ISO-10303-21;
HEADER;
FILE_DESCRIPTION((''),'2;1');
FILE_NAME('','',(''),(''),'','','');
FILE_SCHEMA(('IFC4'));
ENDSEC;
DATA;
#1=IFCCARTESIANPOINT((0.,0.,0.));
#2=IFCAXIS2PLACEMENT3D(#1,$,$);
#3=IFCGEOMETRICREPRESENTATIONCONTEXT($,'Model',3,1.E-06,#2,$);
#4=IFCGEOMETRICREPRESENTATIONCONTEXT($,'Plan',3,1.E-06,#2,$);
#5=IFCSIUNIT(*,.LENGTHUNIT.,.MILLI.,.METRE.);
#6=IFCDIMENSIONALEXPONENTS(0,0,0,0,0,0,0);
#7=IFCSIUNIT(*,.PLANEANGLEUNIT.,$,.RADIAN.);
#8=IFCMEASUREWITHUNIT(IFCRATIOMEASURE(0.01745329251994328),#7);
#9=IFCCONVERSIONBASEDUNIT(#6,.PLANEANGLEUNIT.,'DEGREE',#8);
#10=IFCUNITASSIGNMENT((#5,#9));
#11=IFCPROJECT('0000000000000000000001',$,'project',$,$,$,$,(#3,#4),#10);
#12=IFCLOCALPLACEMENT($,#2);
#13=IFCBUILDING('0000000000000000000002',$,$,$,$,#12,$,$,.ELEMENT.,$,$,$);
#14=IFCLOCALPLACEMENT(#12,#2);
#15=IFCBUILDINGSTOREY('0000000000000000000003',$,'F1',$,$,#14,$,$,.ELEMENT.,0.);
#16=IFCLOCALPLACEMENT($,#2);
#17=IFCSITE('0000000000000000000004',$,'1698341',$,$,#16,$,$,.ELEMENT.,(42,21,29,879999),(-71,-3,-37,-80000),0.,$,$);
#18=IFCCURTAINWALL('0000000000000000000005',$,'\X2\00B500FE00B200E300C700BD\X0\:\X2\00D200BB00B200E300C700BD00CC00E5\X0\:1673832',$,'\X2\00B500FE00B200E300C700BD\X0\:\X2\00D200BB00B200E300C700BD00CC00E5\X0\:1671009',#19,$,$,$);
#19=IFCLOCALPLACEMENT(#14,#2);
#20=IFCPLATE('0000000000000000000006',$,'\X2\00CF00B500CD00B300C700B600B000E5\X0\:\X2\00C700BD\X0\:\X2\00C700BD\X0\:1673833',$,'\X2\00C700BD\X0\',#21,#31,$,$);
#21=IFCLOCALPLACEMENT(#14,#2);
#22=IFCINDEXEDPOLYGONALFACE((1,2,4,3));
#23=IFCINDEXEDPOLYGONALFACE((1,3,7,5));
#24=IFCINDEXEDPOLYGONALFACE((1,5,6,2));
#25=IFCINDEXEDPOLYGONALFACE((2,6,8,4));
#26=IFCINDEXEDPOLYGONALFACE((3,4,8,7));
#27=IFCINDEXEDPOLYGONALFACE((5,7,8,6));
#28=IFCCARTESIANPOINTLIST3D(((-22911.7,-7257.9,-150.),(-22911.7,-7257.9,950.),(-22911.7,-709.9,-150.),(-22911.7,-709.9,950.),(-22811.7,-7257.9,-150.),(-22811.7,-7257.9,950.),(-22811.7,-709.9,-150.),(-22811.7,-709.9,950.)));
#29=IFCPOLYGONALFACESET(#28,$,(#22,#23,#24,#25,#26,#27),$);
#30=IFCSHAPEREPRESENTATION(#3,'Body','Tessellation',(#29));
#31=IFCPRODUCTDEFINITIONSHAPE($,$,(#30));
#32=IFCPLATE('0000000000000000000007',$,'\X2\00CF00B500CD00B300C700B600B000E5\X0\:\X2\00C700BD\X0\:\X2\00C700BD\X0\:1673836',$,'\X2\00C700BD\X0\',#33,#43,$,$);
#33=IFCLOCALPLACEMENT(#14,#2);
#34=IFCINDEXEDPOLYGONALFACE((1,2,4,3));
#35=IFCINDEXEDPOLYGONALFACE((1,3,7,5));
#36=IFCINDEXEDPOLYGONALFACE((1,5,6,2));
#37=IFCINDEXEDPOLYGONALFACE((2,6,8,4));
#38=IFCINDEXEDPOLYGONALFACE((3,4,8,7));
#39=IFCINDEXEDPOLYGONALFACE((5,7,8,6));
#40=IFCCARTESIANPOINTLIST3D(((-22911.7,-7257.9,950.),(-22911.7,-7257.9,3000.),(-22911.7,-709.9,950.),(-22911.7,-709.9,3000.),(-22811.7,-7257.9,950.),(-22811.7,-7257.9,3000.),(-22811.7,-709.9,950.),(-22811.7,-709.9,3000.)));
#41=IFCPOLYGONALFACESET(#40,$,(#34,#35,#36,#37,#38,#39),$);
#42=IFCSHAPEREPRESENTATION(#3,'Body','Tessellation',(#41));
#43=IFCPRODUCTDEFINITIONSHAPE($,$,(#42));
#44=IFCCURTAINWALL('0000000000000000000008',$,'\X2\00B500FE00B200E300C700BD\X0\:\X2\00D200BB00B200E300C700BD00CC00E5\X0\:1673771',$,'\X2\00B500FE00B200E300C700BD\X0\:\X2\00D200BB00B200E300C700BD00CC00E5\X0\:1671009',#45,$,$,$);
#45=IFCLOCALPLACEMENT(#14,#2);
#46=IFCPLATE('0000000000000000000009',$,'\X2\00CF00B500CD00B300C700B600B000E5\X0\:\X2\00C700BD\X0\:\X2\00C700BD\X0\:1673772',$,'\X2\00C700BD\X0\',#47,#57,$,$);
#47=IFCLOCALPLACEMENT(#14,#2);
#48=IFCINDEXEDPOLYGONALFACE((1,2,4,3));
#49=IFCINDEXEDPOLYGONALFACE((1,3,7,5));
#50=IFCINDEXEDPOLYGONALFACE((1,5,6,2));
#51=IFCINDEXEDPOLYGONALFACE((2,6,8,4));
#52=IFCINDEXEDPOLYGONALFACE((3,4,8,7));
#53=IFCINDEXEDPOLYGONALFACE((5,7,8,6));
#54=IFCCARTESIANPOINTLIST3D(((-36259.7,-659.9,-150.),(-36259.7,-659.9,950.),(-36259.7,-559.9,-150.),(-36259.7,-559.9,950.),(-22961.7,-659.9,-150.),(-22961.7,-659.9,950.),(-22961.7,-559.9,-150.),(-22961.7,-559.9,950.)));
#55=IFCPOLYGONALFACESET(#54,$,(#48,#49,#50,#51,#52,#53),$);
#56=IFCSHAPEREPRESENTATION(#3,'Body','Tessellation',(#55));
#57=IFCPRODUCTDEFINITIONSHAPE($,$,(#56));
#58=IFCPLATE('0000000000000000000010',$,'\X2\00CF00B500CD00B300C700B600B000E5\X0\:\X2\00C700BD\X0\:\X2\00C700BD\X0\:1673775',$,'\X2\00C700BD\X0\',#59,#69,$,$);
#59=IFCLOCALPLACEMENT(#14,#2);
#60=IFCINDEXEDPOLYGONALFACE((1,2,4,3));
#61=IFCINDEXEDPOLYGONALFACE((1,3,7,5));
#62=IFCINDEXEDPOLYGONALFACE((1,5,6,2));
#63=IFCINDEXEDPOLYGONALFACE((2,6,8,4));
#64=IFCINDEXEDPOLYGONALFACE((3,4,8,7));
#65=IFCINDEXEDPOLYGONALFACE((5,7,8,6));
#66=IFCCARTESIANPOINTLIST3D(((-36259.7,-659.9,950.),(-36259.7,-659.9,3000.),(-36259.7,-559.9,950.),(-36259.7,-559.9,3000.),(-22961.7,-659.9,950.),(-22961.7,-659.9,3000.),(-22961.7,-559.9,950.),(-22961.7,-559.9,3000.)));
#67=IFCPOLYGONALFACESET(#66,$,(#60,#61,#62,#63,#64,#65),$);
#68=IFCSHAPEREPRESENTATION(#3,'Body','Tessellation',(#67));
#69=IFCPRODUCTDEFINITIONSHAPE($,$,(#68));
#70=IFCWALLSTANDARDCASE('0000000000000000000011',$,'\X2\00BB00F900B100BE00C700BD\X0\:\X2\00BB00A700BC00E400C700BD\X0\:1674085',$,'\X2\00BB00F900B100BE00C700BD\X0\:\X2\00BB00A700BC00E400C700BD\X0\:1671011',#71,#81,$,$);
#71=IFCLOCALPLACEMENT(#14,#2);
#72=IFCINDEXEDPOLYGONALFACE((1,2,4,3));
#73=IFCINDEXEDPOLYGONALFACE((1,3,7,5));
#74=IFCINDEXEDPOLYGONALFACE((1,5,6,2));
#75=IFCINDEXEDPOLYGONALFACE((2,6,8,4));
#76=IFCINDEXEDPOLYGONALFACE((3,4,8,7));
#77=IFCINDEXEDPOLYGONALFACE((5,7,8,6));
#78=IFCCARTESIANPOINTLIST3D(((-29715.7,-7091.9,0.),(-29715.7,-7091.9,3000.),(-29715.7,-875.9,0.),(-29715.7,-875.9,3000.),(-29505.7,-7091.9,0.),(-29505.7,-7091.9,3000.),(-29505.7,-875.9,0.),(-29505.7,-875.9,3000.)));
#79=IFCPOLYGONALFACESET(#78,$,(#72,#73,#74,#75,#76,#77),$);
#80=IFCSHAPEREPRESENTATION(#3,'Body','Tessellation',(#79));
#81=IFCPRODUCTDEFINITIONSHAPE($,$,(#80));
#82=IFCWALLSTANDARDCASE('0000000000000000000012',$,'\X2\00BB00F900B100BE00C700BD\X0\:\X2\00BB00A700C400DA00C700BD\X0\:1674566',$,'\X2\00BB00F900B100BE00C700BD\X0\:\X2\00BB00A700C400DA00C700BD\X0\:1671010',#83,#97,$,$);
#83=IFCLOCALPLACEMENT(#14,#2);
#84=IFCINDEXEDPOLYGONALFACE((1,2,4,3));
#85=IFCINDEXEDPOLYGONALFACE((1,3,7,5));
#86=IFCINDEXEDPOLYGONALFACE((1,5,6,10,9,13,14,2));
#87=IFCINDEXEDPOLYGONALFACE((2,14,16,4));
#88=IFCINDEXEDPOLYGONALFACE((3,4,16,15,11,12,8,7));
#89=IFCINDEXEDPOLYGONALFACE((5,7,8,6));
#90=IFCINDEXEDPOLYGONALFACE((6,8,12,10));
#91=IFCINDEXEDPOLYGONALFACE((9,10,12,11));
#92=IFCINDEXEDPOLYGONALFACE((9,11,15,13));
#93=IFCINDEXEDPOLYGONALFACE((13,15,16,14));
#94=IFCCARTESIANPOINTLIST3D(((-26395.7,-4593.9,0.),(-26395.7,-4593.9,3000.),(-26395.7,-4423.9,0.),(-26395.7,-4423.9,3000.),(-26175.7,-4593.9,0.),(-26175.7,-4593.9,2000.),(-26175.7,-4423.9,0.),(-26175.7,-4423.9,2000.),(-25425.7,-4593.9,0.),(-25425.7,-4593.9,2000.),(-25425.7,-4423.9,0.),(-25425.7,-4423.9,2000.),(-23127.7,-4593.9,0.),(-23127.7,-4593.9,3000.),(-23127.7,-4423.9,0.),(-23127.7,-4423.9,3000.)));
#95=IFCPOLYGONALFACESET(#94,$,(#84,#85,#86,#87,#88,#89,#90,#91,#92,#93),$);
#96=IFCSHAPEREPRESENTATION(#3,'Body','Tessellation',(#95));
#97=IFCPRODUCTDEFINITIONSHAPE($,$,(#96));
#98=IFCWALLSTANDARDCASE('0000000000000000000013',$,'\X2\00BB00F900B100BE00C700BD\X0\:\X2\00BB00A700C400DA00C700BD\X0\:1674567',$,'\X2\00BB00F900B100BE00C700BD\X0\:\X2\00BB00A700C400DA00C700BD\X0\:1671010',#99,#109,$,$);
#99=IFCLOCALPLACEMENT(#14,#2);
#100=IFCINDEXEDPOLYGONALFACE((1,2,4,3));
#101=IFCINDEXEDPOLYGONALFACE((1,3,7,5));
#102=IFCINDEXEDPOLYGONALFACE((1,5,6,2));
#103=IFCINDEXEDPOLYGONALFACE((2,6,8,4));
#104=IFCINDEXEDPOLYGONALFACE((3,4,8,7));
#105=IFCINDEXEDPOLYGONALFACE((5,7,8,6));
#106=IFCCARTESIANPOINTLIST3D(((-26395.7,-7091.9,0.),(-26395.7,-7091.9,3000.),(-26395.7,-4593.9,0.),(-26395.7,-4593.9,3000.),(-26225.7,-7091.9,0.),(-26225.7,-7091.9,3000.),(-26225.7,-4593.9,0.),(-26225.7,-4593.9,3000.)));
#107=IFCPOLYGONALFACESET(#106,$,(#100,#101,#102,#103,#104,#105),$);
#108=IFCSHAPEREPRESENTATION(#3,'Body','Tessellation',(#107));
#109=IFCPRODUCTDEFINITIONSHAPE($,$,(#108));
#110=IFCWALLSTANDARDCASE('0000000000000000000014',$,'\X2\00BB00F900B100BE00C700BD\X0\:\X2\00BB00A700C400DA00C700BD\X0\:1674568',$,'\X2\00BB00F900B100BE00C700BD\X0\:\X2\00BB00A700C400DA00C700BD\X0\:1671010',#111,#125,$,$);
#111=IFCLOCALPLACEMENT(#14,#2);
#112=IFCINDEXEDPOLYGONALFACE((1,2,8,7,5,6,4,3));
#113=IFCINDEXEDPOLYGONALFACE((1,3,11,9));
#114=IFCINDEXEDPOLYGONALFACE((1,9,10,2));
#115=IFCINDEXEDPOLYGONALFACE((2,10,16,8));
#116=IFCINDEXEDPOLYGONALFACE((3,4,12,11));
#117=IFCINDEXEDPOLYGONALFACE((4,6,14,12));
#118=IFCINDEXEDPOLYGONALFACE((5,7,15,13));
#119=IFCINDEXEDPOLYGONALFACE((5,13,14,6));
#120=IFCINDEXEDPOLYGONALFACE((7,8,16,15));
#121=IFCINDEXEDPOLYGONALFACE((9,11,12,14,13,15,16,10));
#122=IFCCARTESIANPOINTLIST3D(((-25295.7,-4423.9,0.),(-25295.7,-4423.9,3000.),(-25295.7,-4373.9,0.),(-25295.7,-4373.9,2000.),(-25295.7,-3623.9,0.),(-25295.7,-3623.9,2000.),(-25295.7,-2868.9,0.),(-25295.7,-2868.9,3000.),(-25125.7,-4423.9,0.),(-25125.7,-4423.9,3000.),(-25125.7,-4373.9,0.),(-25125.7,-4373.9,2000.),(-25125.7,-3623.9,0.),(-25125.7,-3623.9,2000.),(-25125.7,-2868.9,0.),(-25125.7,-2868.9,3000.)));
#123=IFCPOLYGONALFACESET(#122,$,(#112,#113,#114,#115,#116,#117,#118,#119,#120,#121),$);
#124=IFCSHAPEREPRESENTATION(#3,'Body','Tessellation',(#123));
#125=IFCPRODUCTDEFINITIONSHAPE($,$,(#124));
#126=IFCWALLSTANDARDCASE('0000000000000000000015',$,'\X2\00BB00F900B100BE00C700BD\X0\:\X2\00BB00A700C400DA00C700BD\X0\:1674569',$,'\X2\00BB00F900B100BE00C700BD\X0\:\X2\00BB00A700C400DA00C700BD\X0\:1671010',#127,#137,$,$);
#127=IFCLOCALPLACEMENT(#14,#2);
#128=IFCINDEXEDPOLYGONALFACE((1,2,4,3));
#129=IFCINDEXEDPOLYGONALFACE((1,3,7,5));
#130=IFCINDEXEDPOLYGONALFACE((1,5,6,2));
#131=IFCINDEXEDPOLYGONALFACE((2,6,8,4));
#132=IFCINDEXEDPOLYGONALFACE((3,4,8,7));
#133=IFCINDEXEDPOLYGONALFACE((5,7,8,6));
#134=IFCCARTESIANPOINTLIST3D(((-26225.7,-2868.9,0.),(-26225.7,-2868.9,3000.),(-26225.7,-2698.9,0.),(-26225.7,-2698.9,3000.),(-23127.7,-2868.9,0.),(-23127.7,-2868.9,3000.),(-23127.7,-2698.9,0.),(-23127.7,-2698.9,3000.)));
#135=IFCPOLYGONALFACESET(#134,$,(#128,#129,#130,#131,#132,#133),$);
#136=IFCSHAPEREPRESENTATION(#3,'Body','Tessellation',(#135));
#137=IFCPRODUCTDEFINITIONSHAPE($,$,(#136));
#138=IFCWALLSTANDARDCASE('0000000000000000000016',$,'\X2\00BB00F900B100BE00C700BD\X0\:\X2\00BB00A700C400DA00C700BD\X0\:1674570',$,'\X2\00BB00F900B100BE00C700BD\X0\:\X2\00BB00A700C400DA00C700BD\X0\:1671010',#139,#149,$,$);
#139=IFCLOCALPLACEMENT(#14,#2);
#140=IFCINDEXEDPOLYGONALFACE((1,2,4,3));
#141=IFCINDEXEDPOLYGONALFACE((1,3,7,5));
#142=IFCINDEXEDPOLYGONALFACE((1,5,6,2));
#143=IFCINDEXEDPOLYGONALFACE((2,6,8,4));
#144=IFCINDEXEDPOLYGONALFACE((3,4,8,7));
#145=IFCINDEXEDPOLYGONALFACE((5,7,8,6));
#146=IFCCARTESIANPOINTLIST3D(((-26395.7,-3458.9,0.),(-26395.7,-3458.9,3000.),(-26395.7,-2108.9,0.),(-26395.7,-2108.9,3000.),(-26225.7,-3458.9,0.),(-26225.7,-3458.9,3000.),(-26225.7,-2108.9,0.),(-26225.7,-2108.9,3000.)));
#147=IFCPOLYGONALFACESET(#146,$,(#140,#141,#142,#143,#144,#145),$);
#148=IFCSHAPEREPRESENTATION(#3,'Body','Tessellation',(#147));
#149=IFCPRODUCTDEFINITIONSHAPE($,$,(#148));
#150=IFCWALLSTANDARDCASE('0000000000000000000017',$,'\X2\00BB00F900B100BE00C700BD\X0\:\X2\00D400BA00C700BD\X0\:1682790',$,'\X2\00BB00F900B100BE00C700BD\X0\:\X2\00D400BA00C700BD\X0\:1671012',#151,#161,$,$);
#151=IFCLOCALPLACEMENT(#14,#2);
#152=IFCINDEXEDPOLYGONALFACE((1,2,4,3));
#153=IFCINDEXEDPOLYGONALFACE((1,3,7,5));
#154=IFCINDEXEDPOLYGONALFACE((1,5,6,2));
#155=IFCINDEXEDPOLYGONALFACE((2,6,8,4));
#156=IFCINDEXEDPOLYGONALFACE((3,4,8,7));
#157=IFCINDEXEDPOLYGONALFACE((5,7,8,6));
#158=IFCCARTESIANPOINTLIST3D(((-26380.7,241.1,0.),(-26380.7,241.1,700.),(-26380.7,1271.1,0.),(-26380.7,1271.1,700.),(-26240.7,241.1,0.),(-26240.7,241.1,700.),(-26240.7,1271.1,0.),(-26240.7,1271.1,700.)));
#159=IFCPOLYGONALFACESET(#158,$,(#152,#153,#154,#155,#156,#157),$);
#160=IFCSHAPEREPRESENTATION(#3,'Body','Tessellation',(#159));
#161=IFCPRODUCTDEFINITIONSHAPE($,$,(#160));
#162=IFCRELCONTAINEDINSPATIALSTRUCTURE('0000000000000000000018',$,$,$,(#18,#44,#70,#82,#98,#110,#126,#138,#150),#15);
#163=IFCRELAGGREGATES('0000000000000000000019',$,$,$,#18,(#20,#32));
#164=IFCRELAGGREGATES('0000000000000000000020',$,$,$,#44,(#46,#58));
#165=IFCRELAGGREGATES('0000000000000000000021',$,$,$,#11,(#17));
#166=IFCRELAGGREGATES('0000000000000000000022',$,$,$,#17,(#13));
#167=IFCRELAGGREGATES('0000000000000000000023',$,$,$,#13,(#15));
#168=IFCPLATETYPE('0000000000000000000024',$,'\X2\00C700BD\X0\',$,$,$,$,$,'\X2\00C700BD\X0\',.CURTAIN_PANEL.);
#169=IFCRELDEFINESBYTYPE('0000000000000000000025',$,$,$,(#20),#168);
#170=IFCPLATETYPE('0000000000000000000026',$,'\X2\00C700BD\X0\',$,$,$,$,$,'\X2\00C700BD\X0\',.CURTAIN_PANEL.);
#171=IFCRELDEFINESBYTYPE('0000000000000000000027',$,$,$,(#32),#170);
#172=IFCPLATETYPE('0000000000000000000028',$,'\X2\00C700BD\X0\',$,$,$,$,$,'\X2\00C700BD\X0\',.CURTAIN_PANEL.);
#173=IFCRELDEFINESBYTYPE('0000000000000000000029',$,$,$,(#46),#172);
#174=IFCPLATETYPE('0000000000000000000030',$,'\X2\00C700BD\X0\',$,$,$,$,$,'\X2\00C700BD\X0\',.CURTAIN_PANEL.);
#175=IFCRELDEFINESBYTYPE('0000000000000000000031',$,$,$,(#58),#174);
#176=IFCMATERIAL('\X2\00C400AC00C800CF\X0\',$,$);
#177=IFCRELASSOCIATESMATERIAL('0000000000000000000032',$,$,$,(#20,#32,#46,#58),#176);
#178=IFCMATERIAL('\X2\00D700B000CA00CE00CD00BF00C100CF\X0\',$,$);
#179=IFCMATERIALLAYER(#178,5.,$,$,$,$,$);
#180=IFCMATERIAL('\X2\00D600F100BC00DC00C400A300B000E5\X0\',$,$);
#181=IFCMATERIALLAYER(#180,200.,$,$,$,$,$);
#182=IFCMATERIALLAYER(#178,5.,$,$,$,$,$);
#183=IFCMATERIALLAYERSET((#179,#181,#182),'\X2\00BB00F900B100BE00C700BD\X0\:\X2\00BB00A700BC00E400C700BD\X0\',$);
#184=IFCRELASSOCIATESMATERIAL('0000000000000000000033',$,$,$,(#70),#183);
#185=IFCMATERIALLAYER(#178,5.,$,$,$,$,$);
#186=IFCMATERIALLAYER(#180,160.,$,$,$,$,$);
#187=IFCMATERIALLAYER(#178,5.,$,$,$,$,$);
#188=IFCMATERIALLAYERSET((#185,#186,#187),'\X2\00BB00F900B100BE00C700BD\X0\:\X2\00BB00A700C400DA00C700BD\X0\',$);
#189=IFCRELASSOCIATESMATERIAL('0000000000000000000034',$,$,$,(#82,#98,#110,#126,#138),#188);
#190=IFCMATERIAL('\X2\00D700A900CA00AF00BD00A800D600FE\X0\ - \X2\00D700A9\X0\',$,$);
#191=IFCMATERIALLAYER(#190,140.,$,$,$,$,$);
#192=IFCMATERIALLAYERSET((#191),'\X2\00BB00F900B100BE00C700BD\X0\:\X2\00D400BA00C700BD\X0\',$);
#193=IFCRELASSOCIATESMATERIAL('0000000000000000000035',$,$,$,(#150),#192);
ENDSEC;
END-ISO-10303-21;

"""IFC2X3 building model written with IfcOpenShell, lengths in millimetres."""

from ifc_helpers import new_model, entity, si_unit, converted_unit, frame, frame_2d, origin, origin_2d_with_axis, place, context, project, spatial, rectangle, extrude, source, transform, mapped, material, layer, layer_set, layer_usage, type_object, type_shapes, element, aggregate, save


model = new_model("IFC2X3")

# Units and contexts
model_context = context("Model", 3, precision=1e-06, world=origin())
plan_context = context("Plan", 3, precision=1e-06, world=origin())
ifc_project = project(units=[si_unit("LENGTHUNIT", "METRE", prefix="MILLI"), converted_unit("PLANEANGLEUNIT", "DEGREE", entity("IfcRatioMeasure", 0.01745329251994328), si_unit("PLANEANGLEUNIT", "RADIAN"), dimensions=[0, 0, 0, 0, 0, 0, 0])], contexts=[model_context, plan_context])

# Site, building, storey
site_placement = place(None, origin())
site = spatial("IfcSite", under=ifc_project, at=site_placement, Name="1698341", CompositionType="ELEMENT", RefLatitude=(42, 21, 29, 879999), RefLongitude=(-71, -3, -37, -80000), RefElevation=0.0)
building_placement = place(None, origin())
building = spatial("IfcBuilding", under=site, at=building_placement, CompositionType="ELEMENT")
storey_placement = place(building_placement, origin())
storey = spatial("IfcBuildingStorey", under=building, at=storey_placement, Name="F1", CompositionType="ELEMENT", Elevation=0.0)

# Curtain walls, plates
curtain_wall_1_placement = place(storey_placement, origin())
curtain_wall_1 = element("IfcCurtainWall", 1, at=curtain_wall_1_placement, inside=storey, Name="µþ²ãÇ½:Ò»²ãÇ½Ìå:1673832", ObjectType="µþ²ãÇ½:Ò»²ãÇ½Ìå:1671009")
ifc_material_1 = material(Name="Ä¬ÈÏ")
plate_type_1 = type_object("IfcPlateType", Name="Ç½", ElementType="Ç½", PredefinedType="CURTAIN_PANEL")
shared_shape_1 = source(origin(), model_context, "Body", "SweptSolid", [
    extrude(rectangle(XDim=100.0, YDim=6548.0, at=origin_2d_with_axis()), frame((0.0, 100.0, 0.0), z_axis=(0.0, 0.0, 1.0), x_axis=(0.0, 1.0, 0.0)), (0.0, 0.0, 1.0), 1100.0),
])
type_shapes(plate_type_1, [shared_shape_1])
plate_1_placement = place(None, frame((-22961.7, -3983.9, -150.0), z_axis=(0.0, 0.0, 1.0), x_axis=(0.0, -1.0, 0.0)))
plate_1 = element("IfcPlate", 2, at=plate_1_placement, type_object=plate_type_1, material=ifc_material_1, Name="ÏµÍ³Ç¶°å:Ç½:Ç½:1673833", ObjectType="Ç½", context=model_context, shape_type="MappedRepresentation", body=[
    mapped(shared_shape_1, transform((0.0, 0.0, 0.0), scale=1.0)),
])
plate_type_2 = type_object("IfcPlateType", Name="Ç½", ElementType="Ç½", PredefinedType="CURTAIN_PANEL")
shared_shape_2 = source(origin(), model_context, "Body", "SweptSolid", [
    extrude(rectangle(XDim=100.0, YDim=6548.0, at=origin_2d_with_axis()), frame((0.0, 100.0, 0.0), z_axis=(0.0, 0.0, 1.0), x_axis=(0.0, 1.0, 0.0)), (0.0, 0.0, 1.0), 2050.0),
])
type_shapes(plate_type_2, [shared_shape_2])
plate_2_placement = place(None, frame((-22961.7, -3983.9, 950.0), z_axis=(0.0, 0.0, 1.0), x_axis=(0.0, -1.0, 0.0)))
plate_2 = element("IfcPlate", 3, at=plate_2_placement, type_object=plate_type_2, material=ifc_material_1, Name="ÏµÍ³Ç¶°å:Ç½:Ç½:1673836", ObjectType="Ç½", context=model_context, shape_type="MappedRepresentation", body=[
    mapped(shared_shape_2, transform((0.0, 0.0, 0.0), scale=1.0)),
])
aggregate(curtain_wall_1, [plate_1, plate_2])
curtain_wall_2_placement = place(storey_placement, origin())
curtain_wall_2 = element("IfcCurtainWall", 4, at=curtain_wall_2_placement, inside=storey, Name="µþ²ãÇ½:Ò»²ãÇ½Ìå:1673771", ObjectType="µþ²ãÇ½:Ò»²ãÇ½Ìå:1671009")
plate_type_3 = type_object("IfcPlateType", Name="Ç½", ElementType="Ç½", PredefinedType="CURTAIN_PANEL")
shared_shape_3 = source(origin(), model_context, "Body", "SweptSolid", [
    extrude(rectangle(XDim=100.0, YDim=13298.0, at=origin_2d_with_axis()), frame((0.0, 100.0, 0.0), z_axis=(0.0, 0.0, 1.0), x_axis=(0.0, 1.0, 0.0)), (0.0, 0.0, 1.0), 1100.0),
])
type_shapes(plate_type_3, [shared_shape_3])
plate_3_placement = place(None, frame((-29610.7, -709.9, -150.0)))
plate_3 = element("IfcPlate", 5, at=plate_3_placement, type_object=plate_type_3, material=ifc_material_1, Name="ÏµÍ³Ç¶°å:Ç½:Ç½:1673772", ObjectType="Ç½", context=model_context, shape_type="MappedRepresentation", body=[
    mapped(shared_shape_3, transform((0.0, 0.0, 0.0), scale=1.0)),
])
plate_type_4 = type_object("IfcPlateType", Name="Ç½", ElementType="Ç½", PredefinedType="CURTAIN_PANEL")
shared_shape_4 = source(origin(), model_context, "Body", "SweptSolid", [
    extrude(rectangle(XDim=100.0, YDim=13298.0, at=origin_2d_with_axis()), frame((0.0, 100.0, 0.0), z_axis=(0.0, 0.0, 1.0), x_axis=(0.0, 1.0, 0.0)), (0.0, 0.0, 1.0), 2050.0),
])
type_shapes(plate_type_4, [shared_shape_4])
plate_4_placement = place(None, frame((-29610.7, -709.9, 950.0)))
plate_4 = element("IfcPlate", 6, at=plate_4_placement, type_object=plate_type_4, material=ifc_material_1, Name="ÏµÍ³Ç¶°å:Ç½:Ç½:1673775", ObjectType="Ç½", context=model_context, shape_type="MappedRepresentation", body=[
    mapped(shared_shape_4, transform((0.0, 0.0, 0.0), scale=1.0)),
])
aggregate(curtain_wall_2, [plate_3, plate_4])

# Shared definitions
ifc_material_2 = material(Name="Öñ¼ÜÄ£°å")
ifc_material_3 = material(Name="×°ÊÎÍ¿ÁÏ")

# Wall
ifc_layer_1 = layer(ifc_material_3, 5.0)
ifc_layer_2 = layer(ifc_material_2, 200.0)
ifc_layer_3 = layer(ifc_material_3, 5.0)
ifc_layer_set_1 = layer_set([ifc_layer_1, ifc_layer_2, ifc_layer_3], Name="»ù±¾Ç½:»§¼äÇ½")
ifc_layer_usage_1 = layer_usage(ifc_layer_set_1, "AXIS2", "NEGATIVE", 105.0)
wall_1_placement = place(storey_placement, frame((-29610.7, -7091.9, 0.0), z_axis=(0.0, 0.0, 1.0), x_axis=(0.0, 1.0, 0.0)))
element("IfcWallStandardCase", 7, at=wall_1_placement, inside=storey, material=ifc_layer_usage_1, Name="»ù±¾Ç½:»§¼äÇ½:1674085", ObjectType="»ù±¾Ç½:»§¼äÇ½:1671011", context=model_context, shape_type="SweptSolid", body=[
    extrude(rectangle(XDim=6216.0, YDim=210.0, at=frame_2d((3108.0, 0.0), x_axis=(-1.0, 0.0))), origin(), (0.0, 0.0, 1.0), 3000.0),
])

# Wall, opening
ifc_layer_4 = layer(ifc_material_3, 5.0)
ifc_layer_5 = layer(ifc_material_2, 160.0)
ifc_layer_6 = layer(ifc_material_3, 5.0)
ifc_layer_set_2 = layer_set([ifc_layer_4, ifc_layer_5, ifc_layer_6], Name="»ù±¾Ç½:»§ÄÚÇ½")
ifc_layer_usage_2 = layer_usage(ifc_layer_set_2, "AXIS2", "POSITIVE", -85.0)
wall_2_placement = place(storey_placement, frame((-23127.7, -4508.9, 0.0), z_axis=(0.0, 0.0, 1.0), x_axis=(-1.0, 0.0, 0.0)))
wall_2 = element("IfcWallStandardCase", 8, at=wall_2_placement, inside=storey, material=ifc_layer_usage_2, Name="»ù±¾Ç½:»§ÄÚÇ½:1674566", ObjectType="»ù±¾Ç½:»§ÄÚÇ½:1671010", context=model_context, shape_type="SweptSolid", body=[
    extrude(rectangle(XDim=3268.0, YDim=170.0, at=frame_2d((1634.0, 0.0), x_axis=(-1.0, 0.0))), origin(), (0.0, 0.0, 1.0), 3000.0),
])
opening_1_placement = place(wall_2_placement, frame((2298.0, -85.0, 0.0)))
element("IfcOpeningElement", 9, at=opening_1_placement, cuts=wall_2, ObjectType="Opening", context=model_context, shape_type="SweptSolid", body=[
    extrude(rectangle(XDim=750.0, YDim=2000.0, at=frame_2d((1000.0, 375.0), x_axis=(0.0, 1.0))), frame((0.0, 0.0, 0.0), z_axis=(0.0, 1.0, 0.0), x_axis=(0.0, 0.0, 1.0)), (0.0, 0.0, 1.0), 170.0),
])

# Wall
ifc_layer_usage_3 = layer_usage(ifc_layer_set_2, "AXIS2", "POSITIVE", -85.0)
wall_3_placement = place(storey_placement, frame((-26310.7, -4593.9, 0.0), z_axis=(0.0, 0.0, 1.0), x_axis=(0.0, -1.0, 0.0)))
element("IfcWallStandardCase", 10, at=wall_3_placement, inside=storey, material=ifc_layer_usage_3, Name="»ù±¾Ç½:»§ÄÚÇ½:1674567", ObjectType="»ù±¾Ç½:»§ÄÚÇ½:1671010", context=model_context, shape_type="SweptSolid", body=[
    extrude(rectangle(XDim=2498.0, YDim=170.0, at=frame_2d((1249.0, 0.0), x_axis=(-1.0, 0.0))), origin(), (0.0, 0.0, 1.0), 3000.0),
])

# Wall, opening
ifc_layer_usage_4 = layer_usage(ifc_layer_set_2, "AXIS2", "POSITIVE", -85.0)
wall_4_placement = place(storey_placement, frame((-25210.7, -4423.9, 0.0), z_axis=(0.0, 0.0, 1.0), x_axis=(0.0, 1.0, 0.0)))
wall_4 = element("IfcWallStandardCase", 11, at=wall_4_placement, inside=storey, material=ifc_layer_usage_4, Name="»ù±¾Ç½:»§ÄÚÇ½:1674568", ObjectType="»ù±¾Ç½:»§ÄÚÇ½:1671010", context=model_context, shape_type="SweptSolid", body=[
    extrude(rectangle(XDim=1555.0, YDim=170.0, at=frame_2d((777.5, 0.0), x_axis=(-1.0, 0.0))), origin(), (0.0, 0.0, 1.0), 3000.0),
])
opening_2_placement = place(wall_4_placement, frame((800.0, 85.0, 0.0)))
element("IfcOpeningElement", 12, at=opening_2_placement, cuts=wall_4, ObjectType="Opening", context=model_context, shape_type="SweptSolid", body=[
    extrude(rectangle(XDim=750.0, YDim=2000.0, at=frame_2d((1000.0, 375.0), x_axis=(0.0, 1.0))), frame((0.0, 0.0, 0.0), z_axis=(0.0, -1.0, 0.0), x_axis=(0.0, 0.0, 1.0)), (0.0, 0.0, 1.0), 170.0),
])

# Walls
ifc_layer_usage_5 = layer_usage(ifc_layer_set_2, "AXIS2", "POSITIVE", -85.0)
wall_5_placement = place(storey_placement, frame((-26225.7, -2783.9, 0.0)))
element("IfcWallStandardCase", 13, at=wall_5_placement, inside=storey, material=ifc_layer_usage_5, Name="»ù±¾Ç½:»§ÄÚÇ½:1674569", ObjectType="»ù±¾Ç½:»§ÄÚÇ½:1671010", context=model_context, shape_type="SweptSolid", body=[
    extrude(rectangle(XDim=3098.0, YDim=170.0, at=frame_2d((1549.0, 0.0), x_axis=(-1.0, 0.0))), origin(), (0.0, 0.0, 1.0), 3000.0),
])
ifc_layer_usage_6 = layer_usage(ifc_layer_set_2, "AXIS2", "POSITIVE", -85.0)
wall_6_placement = place(storey_placement, frame((-26310.7, -3458.9, 0.0), z_axis=(0.0, 0.0, 1.0), x_axis=(0.0, 1.0, 0.0)))
element("IfcWallStandardCase", 14, at=wall_6_placement, inside=storey, material=ifc_layer_usage_6, Name="»ù±¾Ç½:»§ÄÚÇ½:1674570", ObjectType="»ù±¾Ç½:»§ÄÚÇ½:1671010", context=model_context, shape_type="SweptSolid", body=[
    extrude(rectangle(XDim=1350.0, YDim=170.0, at=frame_2d((675.0, 0.0), x_axis=(-1.0, 0.0))), origin(), (0.0, 0.0, 1.0), 3000.0),
])
ifc_material_4 = material(Name="×©Ê¯½¨Öþ - ×©")
ifc_layer_7 = layer(ifc_material_4, 140.0)
ifc_layer_set_3 = layer_set([ifc_layer_7], Name="»ù±¾Ç½:ÔºÇ½")
ifc_layer_usage_7 = layer_usage(ifc_layer_set_3, "AXIS2", "NEGATIVE", 70.0)
wall_7_placement = place(storey_placement, frame((-26310.7, 1271.1, 0.0), z_axis=(0.0, 0.0, 1.0), x_axis=(0.0, -1.0, 0.0)))
element("IfcWallStandardCase", 15, at=wall_7_placement, inside=storey, material=ifc_layer_usage_7, Name="»ù±¾Ç½:ÔºÇ½:1682790", ObjectType="»ù±¾Ç½:ÔºÇ½:1671012", context=model_context, shape_type="SweptSolid", body=[
    extrude(rectangle(XDim=1030.0, YDim=140.0, at=frame_2d((515.0, 0.0), x_axis=(-1.0, 0.0))), origin(), (0.0, 0.0, 1.0), 700.0),
])

save(model, "model.ifc")
